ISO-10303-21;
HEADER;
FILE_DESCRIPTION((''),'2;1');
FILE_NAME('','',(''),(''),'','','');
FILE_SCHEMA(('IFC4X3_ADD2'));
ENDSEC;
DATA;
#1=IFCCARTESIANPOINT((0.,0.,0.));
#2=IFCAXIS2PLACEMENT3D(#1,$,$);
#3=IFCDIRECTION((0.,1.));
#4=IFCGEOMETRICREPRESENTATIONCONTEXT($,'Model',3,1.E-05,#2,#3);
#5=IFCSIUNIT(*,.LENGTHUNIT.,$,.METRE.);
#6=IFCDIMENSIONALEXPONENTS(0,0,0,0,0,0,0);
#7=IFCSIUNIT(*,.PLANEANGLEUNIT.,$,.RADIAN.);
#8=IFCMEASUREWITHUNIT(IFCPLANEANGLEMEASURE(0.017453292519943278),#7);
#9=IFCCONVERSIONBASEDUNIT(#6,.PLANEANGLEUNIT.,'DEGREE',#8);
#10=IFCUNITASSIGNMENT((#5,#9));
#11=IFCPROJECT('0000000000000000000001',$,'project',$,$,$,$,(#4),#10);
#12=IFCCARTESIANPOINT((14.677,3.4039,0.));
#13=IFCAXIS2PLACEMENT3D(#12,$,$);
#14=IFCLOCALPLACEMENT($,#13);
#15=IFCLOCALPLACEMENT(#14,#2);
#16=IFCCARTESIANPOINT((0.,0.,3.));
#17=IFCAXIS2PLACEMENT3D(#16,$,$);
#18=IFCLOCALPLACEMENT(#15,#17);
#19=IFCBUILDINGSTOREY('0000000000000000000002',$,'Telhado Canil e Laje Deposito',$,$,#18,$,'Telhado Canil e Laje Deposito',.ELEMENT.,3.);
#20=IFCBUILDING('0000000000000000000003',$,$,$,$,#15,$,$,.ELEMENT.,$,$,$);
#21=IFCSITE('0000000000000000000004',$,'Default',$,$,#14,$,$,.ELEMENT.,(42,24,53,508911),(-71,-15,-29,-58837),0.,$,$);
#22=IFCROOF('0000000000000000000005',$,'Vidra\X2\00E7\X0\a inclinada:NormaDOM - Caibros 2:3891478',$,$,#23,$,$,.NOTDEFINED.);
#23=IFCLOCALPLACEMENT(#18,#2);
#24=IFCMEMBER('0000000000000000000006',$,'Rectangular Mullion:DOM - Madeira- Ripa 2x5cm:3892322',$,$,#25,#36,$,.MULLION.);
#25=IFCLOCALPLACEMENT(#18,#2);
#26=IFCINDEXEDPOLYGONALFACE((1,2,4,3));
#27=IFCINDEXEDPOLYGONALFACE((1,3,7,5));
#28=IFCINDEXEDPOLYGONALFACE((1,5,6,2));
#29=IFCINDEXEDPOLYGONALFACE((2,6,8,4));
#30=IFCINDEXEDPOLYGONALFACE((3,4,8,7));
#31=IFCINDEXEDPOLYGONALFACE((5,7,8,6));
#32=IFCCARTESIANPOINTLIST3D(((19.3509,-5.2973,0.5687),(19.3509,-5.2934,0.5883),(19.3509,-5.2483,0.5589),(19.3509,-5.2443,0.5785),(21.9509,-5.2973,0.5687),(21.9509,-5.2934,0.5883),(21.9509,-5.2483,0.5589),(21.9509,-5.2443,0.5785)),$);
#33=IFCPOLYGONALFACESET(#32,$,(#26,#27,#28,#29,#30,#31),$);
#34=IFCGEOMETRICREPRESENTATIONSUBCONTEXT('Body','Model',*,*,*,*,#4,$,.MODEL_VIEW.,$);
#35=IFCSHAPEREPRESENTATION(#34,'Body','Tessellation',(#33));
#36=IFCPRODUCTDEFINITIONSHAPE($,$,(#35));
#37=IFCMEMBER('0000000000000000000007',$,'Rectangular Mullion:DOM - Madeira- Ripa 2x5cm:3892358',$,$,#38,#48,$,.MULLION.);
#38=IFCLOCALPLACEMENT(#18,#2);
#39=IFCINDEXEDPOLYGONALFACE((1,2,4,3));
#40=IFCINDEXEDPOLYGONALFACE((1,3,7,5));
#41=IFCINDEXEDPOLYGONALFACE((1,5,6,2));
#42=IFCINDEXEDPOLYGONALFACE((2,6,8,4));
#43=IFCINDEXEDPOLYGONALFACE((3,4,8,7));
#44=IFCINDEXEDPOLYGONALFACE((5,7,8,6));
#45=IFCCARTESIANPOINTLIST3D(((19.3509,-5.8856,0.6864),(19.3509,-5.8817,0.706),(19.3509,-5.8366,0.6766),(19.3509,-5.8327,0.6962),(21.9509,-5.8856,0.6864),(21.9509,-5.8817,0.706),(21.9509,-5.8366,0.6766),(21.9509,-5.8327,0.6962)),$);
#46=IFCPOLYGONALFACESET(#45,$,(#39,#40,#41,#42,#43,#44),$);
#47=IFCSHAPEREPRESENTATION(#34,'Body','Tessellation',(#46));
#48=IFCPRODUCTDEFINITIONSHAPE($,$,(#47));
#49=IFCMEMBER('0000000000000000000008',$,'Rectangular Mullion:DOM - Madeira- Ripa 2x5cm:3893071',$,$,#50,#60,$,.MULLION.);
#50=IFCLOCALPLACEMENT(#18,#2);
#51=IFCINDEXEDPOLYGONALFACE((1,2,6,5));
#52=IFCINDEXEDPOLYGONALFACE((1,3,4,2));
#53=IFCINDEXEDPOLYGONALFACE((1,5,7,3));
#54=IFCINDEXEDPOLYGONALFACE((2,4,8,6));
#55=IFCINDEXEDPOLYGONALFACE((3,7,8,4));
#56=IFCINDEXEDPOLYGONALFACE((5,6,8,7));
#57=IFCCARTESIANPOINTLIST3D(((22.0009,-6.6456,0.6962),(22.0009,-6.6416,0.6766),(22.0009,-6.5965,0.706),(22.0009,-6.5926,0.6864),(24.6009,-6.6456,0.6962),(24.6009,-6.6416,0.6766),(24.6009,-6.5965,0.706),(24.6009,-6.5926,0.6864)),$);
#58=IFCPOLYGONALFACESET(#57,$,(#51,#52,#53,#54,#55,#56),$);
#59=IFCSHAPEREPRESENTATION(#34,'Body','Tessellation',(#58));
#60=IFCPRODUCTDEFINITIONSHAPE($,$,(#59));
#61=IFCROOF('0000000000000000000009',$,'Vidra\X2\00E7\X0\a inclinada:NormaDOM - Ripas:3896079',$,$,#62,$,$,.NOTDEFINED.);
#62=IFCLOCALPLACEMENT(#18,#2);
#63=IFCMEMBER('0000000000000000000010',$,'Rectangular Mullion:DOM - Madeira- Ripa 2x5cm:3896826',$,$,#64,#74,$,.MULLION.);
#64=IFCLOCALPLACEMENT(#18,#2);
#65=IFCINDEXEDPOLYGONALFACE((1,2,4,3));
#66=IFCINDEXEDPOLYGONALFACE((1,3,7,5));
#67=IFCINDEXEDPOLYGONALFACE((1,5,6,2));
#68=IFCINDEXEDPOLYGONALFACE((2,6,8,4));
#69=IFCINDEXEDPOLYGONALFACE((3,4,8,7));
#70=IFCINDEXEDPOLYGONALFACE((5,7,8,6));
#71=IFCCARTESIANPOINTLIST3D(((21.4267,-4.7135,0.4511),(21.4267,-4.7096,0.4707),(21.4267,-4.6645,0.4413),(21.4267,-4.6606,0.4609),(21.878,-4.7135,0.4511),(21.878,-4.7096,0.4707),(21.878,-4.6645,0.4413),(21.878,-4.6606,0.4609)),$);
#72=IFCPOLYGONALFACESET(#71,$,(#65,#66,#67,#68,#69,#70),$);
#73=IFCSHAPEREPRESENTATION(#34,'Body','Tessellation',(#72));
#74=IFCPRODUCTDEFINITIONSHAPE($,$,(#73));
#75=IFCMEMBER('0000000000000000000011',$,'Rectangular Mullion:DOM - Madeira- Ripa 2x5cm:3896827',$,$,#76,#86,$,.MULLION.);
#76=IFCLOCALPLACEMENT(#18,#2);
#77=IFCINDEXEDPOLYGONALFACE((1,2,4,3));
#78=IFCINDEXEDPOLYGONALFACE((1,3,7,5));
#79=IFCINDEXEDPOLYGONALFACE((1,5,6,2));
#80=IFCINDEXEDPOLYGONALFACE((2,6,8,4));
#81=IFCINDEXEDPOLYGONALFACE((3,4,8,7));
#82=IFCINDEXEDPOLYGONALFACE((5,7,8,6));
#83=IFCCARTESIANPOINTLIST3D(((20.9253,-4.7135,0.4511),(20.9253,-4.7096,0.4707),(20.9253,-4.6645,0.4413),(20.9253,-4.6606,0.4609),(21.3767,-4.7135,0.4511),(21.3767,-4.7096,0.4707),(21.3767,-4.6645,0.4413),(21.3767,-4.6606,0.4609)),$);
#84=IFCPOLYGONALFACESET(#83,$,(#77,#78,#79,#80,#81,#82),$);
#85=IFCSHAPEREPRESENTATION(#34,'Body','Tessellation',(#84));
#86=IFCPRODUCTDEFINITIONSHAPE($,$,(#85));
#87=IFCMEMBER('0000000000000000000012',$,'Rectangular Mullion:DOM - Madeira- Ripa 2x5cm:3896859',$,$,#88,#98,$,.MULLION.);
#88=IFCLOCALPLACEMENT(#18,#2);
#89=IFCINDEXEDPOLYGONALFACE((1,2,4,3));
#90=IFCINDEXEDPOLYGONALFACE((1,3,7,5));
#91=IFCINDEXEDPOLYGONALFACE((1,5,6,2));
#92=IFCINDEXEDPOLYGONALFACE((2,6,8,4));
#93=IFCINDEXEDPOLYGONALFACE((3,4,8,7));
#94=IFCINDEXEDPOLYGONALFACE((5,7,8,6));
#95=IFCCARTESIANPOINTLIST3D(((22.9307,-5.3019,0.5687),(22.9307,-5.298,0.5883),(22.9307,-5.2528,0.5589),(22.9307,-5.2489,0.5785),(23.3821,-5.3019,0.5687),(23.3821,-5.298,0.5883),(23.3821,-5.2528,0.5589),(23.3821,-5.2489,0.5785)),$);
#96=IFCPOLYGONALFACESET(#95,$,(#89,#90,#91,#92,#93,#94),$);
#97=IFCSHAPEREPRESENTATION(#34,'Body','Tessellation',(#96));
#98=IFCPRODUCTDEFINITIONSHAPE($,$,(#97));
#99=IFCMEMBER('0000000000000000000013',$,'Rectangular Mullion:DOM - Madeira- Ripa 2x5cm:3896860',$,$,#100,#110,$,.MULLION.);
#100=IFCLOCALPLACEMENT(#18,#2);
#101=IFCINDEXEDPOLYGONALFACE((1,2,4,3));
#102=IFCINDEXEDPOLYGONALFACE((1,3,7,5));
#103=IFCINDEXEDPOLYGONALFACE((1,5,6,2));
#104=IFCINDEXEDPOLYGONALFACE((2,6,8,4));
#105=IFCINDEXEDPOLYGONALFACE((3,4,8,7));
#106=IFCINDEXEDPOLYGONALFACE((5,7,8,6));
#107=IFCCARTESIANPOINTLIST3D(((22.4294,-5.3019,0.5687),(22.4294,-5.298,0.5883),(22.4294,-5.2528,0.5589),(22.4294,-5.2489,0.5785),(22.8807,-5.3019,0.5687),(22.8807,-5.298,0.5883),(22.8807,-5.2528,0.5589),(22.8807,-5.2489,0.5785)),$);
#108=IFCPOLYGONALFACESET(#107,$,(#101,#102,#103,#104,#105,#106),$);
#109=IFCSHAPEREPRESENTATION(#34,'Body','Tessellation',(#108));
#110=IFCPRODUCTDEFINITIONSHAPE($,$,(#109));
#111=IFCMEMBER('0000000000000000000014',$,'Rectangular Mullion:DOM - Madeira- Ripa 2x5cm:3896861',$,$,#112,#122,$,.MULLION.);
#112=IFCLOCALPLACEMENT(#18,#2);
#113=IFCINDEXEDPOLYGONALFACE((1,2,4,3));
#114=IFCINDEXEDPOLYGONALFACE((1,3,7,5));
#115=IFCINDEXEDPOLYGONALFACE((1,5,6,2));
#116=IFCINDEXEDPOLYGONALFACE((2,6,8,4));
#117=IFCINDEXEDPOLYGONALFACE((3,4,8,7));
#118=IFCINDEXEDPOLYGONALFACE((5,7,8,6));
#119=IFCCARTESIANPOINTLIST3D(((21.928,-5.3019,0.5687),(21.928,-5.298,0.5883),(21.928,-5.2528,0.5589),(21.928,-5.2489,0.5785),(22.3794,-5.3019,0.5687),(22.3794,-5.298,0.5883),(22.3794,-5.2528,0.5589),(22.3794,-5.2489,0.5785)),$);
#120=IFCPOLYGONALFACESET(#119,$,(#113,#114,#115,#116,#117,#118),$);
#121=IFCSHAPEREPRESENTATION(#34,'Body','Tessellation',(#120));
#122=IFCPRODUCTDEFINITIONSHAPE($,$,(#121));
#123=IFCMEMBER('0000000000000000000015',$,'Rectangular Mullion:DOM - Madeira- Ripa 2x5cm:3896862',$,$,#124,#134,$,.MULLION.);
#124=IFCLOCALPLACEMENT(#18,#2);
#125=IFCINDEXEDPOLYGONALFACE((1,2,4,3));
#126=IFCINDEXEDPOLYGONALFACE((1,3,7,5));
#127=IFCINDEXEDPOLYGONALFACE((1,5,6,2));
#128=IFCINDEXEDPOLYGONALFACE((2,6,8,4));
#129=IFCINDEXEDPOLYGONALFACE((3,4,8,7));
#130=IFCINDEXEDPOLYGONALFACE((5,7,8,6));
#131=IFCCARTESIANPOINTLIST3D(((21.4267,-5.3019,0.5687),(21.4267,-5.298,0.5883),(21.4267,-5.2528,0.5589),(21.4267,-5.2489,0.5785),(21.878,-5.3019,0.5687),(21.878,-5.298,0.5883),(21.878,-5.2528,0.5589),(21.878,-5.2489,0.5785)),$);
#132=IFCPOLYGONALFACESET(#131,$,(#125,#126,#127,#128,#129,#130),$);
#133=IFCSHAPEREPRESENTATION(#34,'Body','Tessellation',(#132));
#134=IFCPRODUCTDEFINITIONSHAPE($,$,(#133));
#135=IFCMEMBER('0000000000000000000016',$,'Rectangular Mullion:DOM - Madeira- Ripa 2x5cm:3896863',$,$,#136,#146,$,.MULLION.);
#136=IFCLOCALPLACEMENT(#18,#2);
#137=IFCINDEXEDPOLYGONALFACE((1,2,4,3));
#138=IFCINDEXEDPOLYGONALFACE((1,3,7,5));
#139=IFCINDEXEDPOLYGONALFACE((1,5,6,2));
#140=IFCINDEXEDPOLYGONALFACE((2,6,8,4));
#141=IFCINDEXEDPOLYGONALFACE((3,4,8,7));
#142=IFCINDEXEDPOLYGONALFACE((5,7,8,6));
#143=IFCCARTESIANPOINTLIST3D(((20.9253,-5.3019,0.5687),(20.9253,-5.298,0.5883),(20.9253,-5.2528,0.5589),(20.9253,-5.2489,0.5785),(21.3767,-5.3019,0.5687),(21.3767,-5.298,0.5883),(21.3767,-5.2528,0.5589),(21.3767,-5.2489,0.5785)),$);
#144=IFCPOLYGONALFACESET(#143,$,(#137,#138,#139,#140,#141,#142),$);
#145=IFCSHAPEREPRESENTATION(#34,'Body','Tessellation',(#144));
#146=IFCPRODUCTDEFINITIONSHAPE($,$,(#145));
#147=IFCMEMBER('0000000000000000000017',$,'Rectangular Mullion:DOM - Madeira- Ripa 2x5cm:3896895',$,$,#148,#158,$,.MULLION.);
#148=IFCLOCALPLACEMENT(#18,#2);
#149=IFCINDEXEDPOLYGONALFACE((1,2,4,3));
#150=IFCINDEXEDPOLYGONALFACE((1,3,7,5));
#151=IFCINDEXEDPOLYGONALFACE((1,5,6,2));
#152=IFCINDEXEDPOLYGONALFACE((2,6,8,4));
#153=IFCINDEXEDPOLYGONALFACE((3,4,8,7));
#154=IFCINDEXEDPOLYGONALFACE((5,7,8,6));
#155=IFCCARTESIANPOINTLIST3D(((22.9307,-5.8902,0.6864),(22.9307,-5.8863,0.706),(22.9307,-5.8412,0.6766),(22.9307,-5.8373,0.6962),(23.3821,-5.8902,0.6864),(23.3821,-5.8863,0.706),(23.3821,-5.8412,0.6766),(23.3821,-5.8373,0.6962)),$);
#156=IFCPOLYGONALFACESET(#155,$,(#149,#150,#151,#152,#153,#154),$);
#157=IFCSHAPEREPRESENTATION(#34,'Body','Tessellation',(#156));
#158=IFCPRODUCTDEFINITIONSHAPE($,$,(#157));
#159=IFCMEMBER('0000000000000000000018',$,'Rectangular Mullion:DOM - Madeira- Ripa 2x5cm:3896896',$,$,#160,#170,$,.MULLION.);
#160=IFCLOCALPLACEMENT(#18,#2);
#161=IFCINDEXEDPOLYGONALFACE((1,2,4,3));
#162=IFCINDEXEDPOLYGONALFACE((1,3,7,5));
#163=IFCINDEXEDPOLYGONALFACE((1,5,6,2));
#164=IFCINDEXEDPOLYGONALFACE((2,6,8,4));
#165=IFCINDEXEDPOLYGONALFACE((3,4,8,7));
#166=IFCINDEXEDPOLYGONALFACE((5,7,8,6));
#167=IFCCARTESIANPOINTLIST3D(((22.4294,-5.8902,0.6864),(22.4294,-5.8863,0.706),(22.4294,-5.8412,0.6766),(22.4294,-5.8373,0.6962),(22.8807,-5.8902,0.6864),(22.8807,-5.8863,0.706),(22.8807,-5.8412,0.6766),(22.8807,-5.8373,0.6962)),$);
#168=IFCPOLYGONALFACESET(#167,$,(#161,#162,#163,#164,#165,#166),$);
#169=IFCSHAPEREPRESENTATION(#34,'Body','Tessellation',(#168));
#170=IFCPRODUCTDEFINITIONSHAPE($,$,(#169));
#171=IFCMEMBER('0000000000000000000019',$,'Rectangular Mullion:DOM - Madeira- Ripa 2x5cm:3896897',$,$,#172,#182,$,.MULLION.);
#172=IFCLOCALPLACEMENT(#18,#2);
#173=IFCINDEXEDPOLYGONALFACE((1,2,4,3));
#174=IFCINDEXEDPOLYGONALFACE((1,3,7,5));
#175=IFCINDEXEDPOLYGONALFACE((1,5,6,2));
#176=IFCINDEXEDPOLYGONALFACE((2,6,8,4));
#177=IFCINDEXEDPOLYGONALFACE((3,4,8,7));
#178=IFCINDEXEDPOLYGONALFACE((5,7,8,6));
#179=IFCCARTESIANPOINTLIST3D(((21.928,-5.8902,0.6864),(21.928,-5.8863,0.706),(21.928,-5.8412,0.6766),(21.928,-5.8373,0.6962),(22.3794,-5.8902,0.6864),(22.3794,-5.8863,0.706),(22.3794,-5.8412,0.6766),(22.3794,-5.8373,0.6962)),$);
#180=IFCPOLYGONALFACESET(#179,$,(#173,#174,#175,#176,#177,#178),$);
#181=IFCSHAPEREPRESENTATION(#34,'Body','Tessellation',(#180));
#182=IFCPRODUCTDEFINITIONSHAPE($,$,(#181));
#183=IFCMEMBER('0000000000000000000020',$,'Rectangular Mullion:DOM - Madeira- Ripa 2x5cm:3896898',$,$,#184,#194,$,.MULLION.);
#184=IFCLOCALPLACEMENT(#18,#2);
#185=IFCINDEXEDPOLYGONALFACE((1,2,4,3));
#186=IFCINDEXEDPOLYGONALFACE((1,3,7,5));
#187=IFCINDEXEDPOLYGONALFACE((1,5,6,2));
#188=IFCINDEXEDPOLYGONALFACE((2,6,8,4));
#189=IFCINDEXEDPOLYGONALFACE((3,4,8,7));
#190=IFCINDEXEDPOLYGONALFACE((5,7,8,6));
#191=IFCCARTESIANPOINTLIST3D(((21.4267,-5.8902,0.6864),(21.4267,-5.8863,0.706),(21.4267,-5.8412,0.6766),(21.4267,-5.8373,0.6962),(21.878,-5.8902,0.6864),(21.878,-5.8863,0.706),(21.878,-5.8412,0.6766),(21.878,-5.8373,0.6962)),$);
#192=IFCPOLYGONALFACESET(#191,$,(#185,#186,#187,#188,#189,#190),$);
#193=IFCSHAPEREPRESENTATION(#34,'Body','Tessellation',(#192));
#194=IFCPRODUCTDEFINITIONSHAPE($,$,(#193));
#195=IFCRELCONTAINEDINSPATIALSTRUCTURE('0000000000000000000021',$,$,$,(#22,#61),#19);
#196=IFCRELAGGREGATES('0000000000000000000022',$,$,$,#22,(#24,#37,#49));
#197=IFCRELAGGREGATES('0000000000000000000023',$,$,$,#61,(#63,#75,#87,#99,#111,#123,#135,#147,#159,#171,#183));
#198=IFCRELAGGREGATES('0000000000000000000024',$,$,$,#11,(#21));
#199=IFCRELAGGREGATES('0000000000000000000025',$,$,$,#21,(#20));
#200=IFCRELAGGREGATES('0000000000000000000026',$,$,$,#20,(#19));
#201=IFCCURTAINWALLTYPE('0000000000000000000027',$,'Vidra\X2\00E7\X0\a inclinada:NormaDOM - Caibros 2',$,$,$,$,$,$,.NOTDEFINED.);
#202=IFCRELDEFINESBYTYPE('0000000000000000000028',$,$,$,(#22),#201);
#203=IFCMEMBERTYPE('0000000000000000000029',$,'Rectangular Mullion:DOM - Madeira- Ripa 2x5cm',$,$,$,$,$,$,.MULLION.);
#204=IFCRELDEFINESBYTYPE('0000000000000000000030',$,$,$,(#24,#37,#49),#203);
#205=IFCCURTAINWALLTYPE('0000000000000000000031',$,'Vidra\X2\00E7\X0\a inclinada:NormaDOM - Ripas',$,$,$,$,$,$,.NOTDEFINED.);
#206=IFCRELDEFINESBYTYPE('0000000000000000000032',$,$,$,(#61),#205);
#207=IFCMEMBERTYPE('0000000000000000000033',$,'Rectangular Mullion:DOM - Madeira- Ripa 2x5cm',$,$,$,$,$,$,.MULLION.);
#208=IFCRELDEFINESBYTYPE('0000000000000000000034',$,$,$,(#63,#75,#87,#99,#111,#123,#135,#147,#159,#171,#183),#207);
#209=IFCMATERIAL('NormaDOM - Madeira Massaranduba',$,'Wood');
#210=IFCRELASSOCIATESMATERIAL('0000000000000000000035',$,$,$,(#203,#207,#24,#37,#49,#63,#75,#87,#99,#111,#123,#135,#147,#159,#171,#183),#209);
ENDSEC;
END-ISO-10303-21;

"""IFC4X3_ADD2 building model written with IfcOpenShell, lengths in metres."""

from ifc_helpers import new_model, entity, si_unit, converted_unit, direction, frame, origin, origin_2d_with_axis, place, context, subcontext, project, spatial, rectangle, extrude, source, transform, mapped, material, material_profile, profile_set, profile_usage, type_object, type_shapes, element, aggregate, save


model = new_model("IFC4X3_ADD2")

# Units and contexts
model_context = context("Model", 3, precision=1e-05, world=origin(), true_north=direction((0.0, 1.0)))
body_context = subcontext(model_context, "Body", "Model", "MODEL_VIEW")
ifc_project = project(units=[si_unit("LENGTHUNIT", "METRE"), converted_unit("PLANEANGLEUNIT", "DEGREE", entity("IfcPlaneAngleMeasure", 0.017453292519943278), si_unit("PLANEANGLEUNIT", "RADIAN"), dimensions=[0, 0, 0, 0, 0, 0, 0])], contexts=[model_context])

# Site, building, storey
site_placement = place(None, frame((14.677, 3.4039, 0.0)))
site = spatial("IfcSite", under=ifc_project, at=site_placement, Name="Default", CompositionType="ELEMENT", RefLatitude=(42, 24, 53, 508911), RefLongitude=(-71, -15, -29, -58837), RefElevation=0.0)
building_placement = place(site_placement, origin())
building = spatial("IfcBuilding", under=site, at=building_placement, CompositionType="ELEMENT")
storey_placement = place(building_placement, frame((0.0, 0.0, 3.0)))
storey = spatial("IfcBuildingStorey", under=building, at=storey_placement, Name="Telhado Canil e Laje Deposito", LongName="Telhado Canil e Laje Deposito", CompositionType="ELEMENT", Elevation=3.0)

# Roofs, members
curtain_wall_type_1 = type_object("IfcCurtainWallType", Name="Vidraça inclinada:NormaDOM - Caibros 2", PredefinedType="NOTDEFINED")
roof_1_placement = place(storey_placement, frame((0.0, 0.0, -3.0)))
roof_1 = element("IfcRoof", 1, at=roof_1_placement, inside=storey, type_object=curtain_wall_type_1, Name="Vidraça inclinada:NormaDOM - Caibros 2:3891478", PredefinedType="NOTDEFINED")
ifc_material = material(Name="NormaDOM - Madeira Massaranduba", Category="Wood")
ifc_material_profile_1 = material_profile(ifc_material, rectangle(XDim=0.05, YDim=0.02, at=origin_2d_with_axis()), Name="DOM - Madeira- Ripa 2x5cm")
ifc_profile_set_1 = profile_set([ifc_material_profile_1], Name="DOM - Madeira- Ripa 2x5cm")
ifc_profile_usage_1 = profile_usage(ifc_profile_set_1)
member_type_1 = type_object("IfcMemberType", Name="Rectangular Mullion:DOM - Madeira- Ripa 2x5cm", PredefinedType="MULLION", material=ifc_profile_set_1)
shared_shape_1 = source(origin(), body_context, "Body", "SweptSolid", [
    extrude(rectangle(XDim=0.05, YDim=0.02, at=origin_2d_with_axis()), frame((0.025, 0.01, -2.6), z_axis=(0.0, 0.0, 1.0), x_axis=(-1.0, 0.0, 0.0)), (0.0, 0.0, 1.0), 2.6),
])
type_shapes(member_type_1, [shared_shape_1])
member_1_placement = place(roof_1_placement, frame((21.9509, -5.2443, 3.5785), z_axis=(1.0, 0.0, 0.0), x_axis=(0.0, -0.980581, 0.196116)))
member_1 = element("IfcMember", 2, at=member_1_placement, type_object=member_type_1, material=ifc_profile_usage_1, Name="Rectangular Mullion:DOM - Madeira- Ripa 2x5cm:3892322", PredefinedType="MULLION", context=body_context, shape_type="MappedRepresentation", body=[
    mapped(shared_shape_1, transform((0.0, 0.0, 0.0), scale=1.0)),
])
member_2_placement = place(roof_1_placement, frame((21.9509, -5.8327, 3.6962), z_axis=(1.0, 0.0, 0.0), x_axis=(0.0, -0.980581, 0.196116)))
member_2 = element("IfcMember", 3, at=member_2_placement, type_object=member_type_1, material=ifc_profile_usage_1, Name="Rectangular Mullion:DOM - Madeira- Ripa 2x5cm:3892358", PredefinedType="MULLION", context=body_context, shape_type="MappedRepresentation", body=[
    mapped(shared_shape_1, transform((0.0, 0.0, 0.0), scale=1.0)),
])
member_3_placement = place(roof_1_placement, frame((22.0009, -6.6456, 3.6962), z_axis=(-1.0, 0.0, 0.0), x_axis=(0.0, 0.980581, 0.196116)))
member_3 = element("IfcMember", 4, at=member_3_placement, type_object=member_type_1, material=ifc_profile_usage_1, Name="Rectangular Mullion:DOM - Madeira- Ripa 2x5cm:3893071", PredefinedType="MULLION", context=body_context, shape_type="MappedRepresentation", body=[
    mapped(shared_shape_1, transform((0.0, 0.0, 0.0), scale=1.0)),
])
curtain_wall_type_2 = type_object("IfcCurtainWallType", Name="Vidraça inclinada:NormaDOM - Ripas", PredefinedType="NOTDEFINED")
roof_2_placement = place(storey_placement, frame((0.0, 0.0, -3.0)))
roof_2 = element("IfcRoof", 5, at=roof_2_placement, inside=storey, type_object=curtain_wall_type_2, Name="Vidraça inclinada:NormaDOM - Ripas:3896079", PredefinedType="NOTDEFINED")

# Members
aggregate(roof_1, [member_1, member_2, member_3])
member_type_2 = type_object("IfcMemberType", Name="Rectangular Mullion:DOM - Madeira- Ripa 2x5cm", PredefinedType="MULLION", material=ifc_profile_set_1)
shared_shape_2 = source(origin(), body_context, "Body", "SweptSolid", [
    extrude(rectangle(XDim=0.05, YDim=0.02, at=origin_2d_with_axis()), frame((0.025, 0.01, -0.4514), z_axis=(0.0, 0.0, 1.0), x_axis=(-1.0, 0.0, 0.0)), (0.0, 0.0, 1.0), 0.4514),
])
type_shapes(member_type_2, [shared_shape_2])
member_4_placement = place(roof_2_placement, frame((21.878, -4.6606, 3.4609), z_axis=(1.0, 0.0, 0.0), x_axis=(0.0, -0.980581, 0.196116)))
member_4 = element("IfcMember", 6, at=member_4_placement, type_object=member_type_2, material=ifc_profile_usage_1, Name="Rectangular Mullion:DOM - Madeira- Ripa 2x5cm:3896826", PredefinedType="MULLION", context=body_context, shape_type="MappedRepresentation", body=[
    mapped(shared_shape_2, transform((0.0, 0.0, 0.0), scale=1.0)),
])
member_5_placement = place(roof_2_placement, frame((21.3767, -4.6606, 3.4609), z_axis=(1.0, 0.0, 0.0), x_axis=(0.0, -0.980581, 0.196116)))
member_5 = element("IfcMember", 7, at=member_5_placement, type_object=member_type_2, material=ifc_profile_usage_1, Name="Rectangular Mullion:DOM - Madeira- Ripa 2x5cm:3896827", PredefinedType="MULLION", context=body_context, shape_type="MappedRepresentation", body=[
    mapped(shared_shape_2, transform((0.0, 0.0, 0.0), scale=1.0)),
])
member_6_placement = place(roof_2_placement, frame((23.3821, -5.2489, 3.5785), z_axis=(1.0, 0.0, 0.0), x_axis=(0.0, -0.980581, 0.196116)))
member_6 = element("IfcMember", 8, at=member_6_placement, type_object=member_type_2, material=ifc_profile_usage_1, Name="Rectangular Mullion:DOM - Madeira- Ripa 2x5cm:3896859", PredefinedType="MULLION", context=body_context, shape_type="MappedRepresentation", body=[
    mapped(shared_shape_2, transform((0.0, 0.0, 0.0), scale=1.0)),
])
member_7_placement = place(roof_2_placement, frame((22.8807, -5.2489, 3.5785), z_axis=(1.0, 0.0, 0.0), x_axis=(0.0, -0.980581, 0.196116)))
member_7 = element("IfcMember", 9, at=member_7_placement, type_object=member_type_2, material=ifc_profile_usage_1, Name="Rectangular Mullion:DOM - Madeira- Ripa 2x5cm:3896860", PredefinedType="MULLION", context=body_context, shape_type="MappedRepresentation", body=[
    mapped(shared_shape_2, transform((0.0, 0.0, 0.0), scale=1.0)),
])
member_8_placement = place(roof_2_placement, frame((22.3794, -5.2489, 3.5785), z_axis=(1.0, 0.0, 0.0), x_axis=(0.0, -0.980581, 0.196116)))
member_8 = element("IfcMember", 10, at=member_8_placement, type_object=member_type_2, material=ifc_profile_usage_1, Name="Rectangular Mullion:DOM - Madeira- Ripa 2x5cm:3896861", PredefinedType="MULLION", context=body_context, shape_type="MappedRepresentation", body=[
    mapped(shared_shape_2, transform((0.0, 0.0, 0.0), scale=1.0)),
])
member_9_placement = place(roof_2_placement, frame((21.878, -5.2489, 3.5785), z_axis=(1.0, 0.0, 0.0), x_axis=(0.0, -0.980581, 0.196116)))
member_9 = element("IfcMember", 11, at=member_9_placement, type_object=member_type_2, material=ifc_profile_usage_1, Name="Rectangular Mullion:DOM - Madeira- Ripa 2x5cm:3896862", PredefinedType="MULLION", context=body_context, shape_type="MappedRepresentation", body=[
    mapped(shared_shape_2, transform((0.0, 0.0, 0.0), scale=1.0)),
])
member_10_placement = place(roof_2_placement, frame((21.3767, -5.2489, 3.5785), z_axis=(1.0, 0.0, 0.0), x_axis=(0.0, -0.980581, 0.196116)))
member_10 = element("IfcMember", 12, at=member_10_placement, type_object=member_type_2, material=ifc_profile_usage_1, Name="Rectangular Mullion:DOM - Madeira- Ripa 2x5cm:3896863", PredefinedType="MULLION", context=body_context, shape_type="MappedRepresentation", body=[
    mapped(shared_shape_2, transform((0.0, 0.0, 0.0), scale=1.0)),
])
member_11_placement = place(roof_2_placement, frame((23.3821, -5.8373, 3.6962), z_axis=(1.0, 0.0, 0.0), x_axis=(0.0, -0.980581, 0.196116)))
member_11 = element("IfcMember", 13, at=member_11_placement, type_object=member_type_2, material=ifc_profile_usage_1, Name="Rectangular Mullion:DOM - Madeira- Ripa 2x5cm:3896895", PredefinedType="MULLION", context=body_context, shape_type="MappedRepresentation", body=[
    mapped(shared_shape_2, transform((0.0, 0.0, 0.0), scale=1.0)),
])
member_12_placement = place(roof_2_placement, frame((22.8807, -5.8373, 3.6962), z_axis=(1.0, 0.0, 0.0), x_axis=(0.0, -0.980581, 0.196116)))
member_12 = element("IfcMember", 14, at=member_12_placement, type_object=member_type_2, material=ifc_profile_usage_1, Name="Rectangular Mullion:DOM - Madeira- Ripa 2x5cm:3896896", PredefinedType="MULLION", context=body_context, shape_type="MappedRepresentation", body=[
    mapped(shared_shape_2, transform((0.0, 0.0, 0.0), scale=1.0)),
])
member_13_placement = place(roof_2_placement, frame((22.3794, -5.8373, 3.6962), z_axis=(1.0, 0.0, 0.0), x_axis=(0.0, -0.980581, 0.196116)))
member_13 = element("IfcMember", 15, at=member_13_placement, type_object=member_type_2, material=ifc_profile_usage_1, Name="Rectangular Mullion:DOM - Madeira- Ripa 2x5cm:3896897", PredefinedType="MULLION", context=body_context, shape_type="MappedRepresentation", body=[
    mapped(shared_shape_2, transform((0.0, 0.0, 0.0), scale=1.0)),
])
member_14_placement = place(roof_2_placement, frame((21.878, -5.8373, 3.6962), z_axis=(1.0, 0.0, 0.0), x_axis=(0.0, -0.980581, 0.196116)))
member_14 = element("IfcMember", 16, at=member_14_placement, type_object=member_type_2, material=ifc_profile_usage_1, Name="Rectangular Mullion:DOM - Madeira- Ripa 2x5cm:3896898", PredefinedType="MULLION", context=body_context, shape_type="MappedRepresentation", body=[
    mapped(shared_shape_2, transform((0.0, 0.0, 0.0), scale=1.0)),
])
aggregate(roof_2, [member_4, member_5, member_6, member_7, member_8, member_9, member_10, member_11, member_12, member_13, member_14])

save(model, "model.ifc")
